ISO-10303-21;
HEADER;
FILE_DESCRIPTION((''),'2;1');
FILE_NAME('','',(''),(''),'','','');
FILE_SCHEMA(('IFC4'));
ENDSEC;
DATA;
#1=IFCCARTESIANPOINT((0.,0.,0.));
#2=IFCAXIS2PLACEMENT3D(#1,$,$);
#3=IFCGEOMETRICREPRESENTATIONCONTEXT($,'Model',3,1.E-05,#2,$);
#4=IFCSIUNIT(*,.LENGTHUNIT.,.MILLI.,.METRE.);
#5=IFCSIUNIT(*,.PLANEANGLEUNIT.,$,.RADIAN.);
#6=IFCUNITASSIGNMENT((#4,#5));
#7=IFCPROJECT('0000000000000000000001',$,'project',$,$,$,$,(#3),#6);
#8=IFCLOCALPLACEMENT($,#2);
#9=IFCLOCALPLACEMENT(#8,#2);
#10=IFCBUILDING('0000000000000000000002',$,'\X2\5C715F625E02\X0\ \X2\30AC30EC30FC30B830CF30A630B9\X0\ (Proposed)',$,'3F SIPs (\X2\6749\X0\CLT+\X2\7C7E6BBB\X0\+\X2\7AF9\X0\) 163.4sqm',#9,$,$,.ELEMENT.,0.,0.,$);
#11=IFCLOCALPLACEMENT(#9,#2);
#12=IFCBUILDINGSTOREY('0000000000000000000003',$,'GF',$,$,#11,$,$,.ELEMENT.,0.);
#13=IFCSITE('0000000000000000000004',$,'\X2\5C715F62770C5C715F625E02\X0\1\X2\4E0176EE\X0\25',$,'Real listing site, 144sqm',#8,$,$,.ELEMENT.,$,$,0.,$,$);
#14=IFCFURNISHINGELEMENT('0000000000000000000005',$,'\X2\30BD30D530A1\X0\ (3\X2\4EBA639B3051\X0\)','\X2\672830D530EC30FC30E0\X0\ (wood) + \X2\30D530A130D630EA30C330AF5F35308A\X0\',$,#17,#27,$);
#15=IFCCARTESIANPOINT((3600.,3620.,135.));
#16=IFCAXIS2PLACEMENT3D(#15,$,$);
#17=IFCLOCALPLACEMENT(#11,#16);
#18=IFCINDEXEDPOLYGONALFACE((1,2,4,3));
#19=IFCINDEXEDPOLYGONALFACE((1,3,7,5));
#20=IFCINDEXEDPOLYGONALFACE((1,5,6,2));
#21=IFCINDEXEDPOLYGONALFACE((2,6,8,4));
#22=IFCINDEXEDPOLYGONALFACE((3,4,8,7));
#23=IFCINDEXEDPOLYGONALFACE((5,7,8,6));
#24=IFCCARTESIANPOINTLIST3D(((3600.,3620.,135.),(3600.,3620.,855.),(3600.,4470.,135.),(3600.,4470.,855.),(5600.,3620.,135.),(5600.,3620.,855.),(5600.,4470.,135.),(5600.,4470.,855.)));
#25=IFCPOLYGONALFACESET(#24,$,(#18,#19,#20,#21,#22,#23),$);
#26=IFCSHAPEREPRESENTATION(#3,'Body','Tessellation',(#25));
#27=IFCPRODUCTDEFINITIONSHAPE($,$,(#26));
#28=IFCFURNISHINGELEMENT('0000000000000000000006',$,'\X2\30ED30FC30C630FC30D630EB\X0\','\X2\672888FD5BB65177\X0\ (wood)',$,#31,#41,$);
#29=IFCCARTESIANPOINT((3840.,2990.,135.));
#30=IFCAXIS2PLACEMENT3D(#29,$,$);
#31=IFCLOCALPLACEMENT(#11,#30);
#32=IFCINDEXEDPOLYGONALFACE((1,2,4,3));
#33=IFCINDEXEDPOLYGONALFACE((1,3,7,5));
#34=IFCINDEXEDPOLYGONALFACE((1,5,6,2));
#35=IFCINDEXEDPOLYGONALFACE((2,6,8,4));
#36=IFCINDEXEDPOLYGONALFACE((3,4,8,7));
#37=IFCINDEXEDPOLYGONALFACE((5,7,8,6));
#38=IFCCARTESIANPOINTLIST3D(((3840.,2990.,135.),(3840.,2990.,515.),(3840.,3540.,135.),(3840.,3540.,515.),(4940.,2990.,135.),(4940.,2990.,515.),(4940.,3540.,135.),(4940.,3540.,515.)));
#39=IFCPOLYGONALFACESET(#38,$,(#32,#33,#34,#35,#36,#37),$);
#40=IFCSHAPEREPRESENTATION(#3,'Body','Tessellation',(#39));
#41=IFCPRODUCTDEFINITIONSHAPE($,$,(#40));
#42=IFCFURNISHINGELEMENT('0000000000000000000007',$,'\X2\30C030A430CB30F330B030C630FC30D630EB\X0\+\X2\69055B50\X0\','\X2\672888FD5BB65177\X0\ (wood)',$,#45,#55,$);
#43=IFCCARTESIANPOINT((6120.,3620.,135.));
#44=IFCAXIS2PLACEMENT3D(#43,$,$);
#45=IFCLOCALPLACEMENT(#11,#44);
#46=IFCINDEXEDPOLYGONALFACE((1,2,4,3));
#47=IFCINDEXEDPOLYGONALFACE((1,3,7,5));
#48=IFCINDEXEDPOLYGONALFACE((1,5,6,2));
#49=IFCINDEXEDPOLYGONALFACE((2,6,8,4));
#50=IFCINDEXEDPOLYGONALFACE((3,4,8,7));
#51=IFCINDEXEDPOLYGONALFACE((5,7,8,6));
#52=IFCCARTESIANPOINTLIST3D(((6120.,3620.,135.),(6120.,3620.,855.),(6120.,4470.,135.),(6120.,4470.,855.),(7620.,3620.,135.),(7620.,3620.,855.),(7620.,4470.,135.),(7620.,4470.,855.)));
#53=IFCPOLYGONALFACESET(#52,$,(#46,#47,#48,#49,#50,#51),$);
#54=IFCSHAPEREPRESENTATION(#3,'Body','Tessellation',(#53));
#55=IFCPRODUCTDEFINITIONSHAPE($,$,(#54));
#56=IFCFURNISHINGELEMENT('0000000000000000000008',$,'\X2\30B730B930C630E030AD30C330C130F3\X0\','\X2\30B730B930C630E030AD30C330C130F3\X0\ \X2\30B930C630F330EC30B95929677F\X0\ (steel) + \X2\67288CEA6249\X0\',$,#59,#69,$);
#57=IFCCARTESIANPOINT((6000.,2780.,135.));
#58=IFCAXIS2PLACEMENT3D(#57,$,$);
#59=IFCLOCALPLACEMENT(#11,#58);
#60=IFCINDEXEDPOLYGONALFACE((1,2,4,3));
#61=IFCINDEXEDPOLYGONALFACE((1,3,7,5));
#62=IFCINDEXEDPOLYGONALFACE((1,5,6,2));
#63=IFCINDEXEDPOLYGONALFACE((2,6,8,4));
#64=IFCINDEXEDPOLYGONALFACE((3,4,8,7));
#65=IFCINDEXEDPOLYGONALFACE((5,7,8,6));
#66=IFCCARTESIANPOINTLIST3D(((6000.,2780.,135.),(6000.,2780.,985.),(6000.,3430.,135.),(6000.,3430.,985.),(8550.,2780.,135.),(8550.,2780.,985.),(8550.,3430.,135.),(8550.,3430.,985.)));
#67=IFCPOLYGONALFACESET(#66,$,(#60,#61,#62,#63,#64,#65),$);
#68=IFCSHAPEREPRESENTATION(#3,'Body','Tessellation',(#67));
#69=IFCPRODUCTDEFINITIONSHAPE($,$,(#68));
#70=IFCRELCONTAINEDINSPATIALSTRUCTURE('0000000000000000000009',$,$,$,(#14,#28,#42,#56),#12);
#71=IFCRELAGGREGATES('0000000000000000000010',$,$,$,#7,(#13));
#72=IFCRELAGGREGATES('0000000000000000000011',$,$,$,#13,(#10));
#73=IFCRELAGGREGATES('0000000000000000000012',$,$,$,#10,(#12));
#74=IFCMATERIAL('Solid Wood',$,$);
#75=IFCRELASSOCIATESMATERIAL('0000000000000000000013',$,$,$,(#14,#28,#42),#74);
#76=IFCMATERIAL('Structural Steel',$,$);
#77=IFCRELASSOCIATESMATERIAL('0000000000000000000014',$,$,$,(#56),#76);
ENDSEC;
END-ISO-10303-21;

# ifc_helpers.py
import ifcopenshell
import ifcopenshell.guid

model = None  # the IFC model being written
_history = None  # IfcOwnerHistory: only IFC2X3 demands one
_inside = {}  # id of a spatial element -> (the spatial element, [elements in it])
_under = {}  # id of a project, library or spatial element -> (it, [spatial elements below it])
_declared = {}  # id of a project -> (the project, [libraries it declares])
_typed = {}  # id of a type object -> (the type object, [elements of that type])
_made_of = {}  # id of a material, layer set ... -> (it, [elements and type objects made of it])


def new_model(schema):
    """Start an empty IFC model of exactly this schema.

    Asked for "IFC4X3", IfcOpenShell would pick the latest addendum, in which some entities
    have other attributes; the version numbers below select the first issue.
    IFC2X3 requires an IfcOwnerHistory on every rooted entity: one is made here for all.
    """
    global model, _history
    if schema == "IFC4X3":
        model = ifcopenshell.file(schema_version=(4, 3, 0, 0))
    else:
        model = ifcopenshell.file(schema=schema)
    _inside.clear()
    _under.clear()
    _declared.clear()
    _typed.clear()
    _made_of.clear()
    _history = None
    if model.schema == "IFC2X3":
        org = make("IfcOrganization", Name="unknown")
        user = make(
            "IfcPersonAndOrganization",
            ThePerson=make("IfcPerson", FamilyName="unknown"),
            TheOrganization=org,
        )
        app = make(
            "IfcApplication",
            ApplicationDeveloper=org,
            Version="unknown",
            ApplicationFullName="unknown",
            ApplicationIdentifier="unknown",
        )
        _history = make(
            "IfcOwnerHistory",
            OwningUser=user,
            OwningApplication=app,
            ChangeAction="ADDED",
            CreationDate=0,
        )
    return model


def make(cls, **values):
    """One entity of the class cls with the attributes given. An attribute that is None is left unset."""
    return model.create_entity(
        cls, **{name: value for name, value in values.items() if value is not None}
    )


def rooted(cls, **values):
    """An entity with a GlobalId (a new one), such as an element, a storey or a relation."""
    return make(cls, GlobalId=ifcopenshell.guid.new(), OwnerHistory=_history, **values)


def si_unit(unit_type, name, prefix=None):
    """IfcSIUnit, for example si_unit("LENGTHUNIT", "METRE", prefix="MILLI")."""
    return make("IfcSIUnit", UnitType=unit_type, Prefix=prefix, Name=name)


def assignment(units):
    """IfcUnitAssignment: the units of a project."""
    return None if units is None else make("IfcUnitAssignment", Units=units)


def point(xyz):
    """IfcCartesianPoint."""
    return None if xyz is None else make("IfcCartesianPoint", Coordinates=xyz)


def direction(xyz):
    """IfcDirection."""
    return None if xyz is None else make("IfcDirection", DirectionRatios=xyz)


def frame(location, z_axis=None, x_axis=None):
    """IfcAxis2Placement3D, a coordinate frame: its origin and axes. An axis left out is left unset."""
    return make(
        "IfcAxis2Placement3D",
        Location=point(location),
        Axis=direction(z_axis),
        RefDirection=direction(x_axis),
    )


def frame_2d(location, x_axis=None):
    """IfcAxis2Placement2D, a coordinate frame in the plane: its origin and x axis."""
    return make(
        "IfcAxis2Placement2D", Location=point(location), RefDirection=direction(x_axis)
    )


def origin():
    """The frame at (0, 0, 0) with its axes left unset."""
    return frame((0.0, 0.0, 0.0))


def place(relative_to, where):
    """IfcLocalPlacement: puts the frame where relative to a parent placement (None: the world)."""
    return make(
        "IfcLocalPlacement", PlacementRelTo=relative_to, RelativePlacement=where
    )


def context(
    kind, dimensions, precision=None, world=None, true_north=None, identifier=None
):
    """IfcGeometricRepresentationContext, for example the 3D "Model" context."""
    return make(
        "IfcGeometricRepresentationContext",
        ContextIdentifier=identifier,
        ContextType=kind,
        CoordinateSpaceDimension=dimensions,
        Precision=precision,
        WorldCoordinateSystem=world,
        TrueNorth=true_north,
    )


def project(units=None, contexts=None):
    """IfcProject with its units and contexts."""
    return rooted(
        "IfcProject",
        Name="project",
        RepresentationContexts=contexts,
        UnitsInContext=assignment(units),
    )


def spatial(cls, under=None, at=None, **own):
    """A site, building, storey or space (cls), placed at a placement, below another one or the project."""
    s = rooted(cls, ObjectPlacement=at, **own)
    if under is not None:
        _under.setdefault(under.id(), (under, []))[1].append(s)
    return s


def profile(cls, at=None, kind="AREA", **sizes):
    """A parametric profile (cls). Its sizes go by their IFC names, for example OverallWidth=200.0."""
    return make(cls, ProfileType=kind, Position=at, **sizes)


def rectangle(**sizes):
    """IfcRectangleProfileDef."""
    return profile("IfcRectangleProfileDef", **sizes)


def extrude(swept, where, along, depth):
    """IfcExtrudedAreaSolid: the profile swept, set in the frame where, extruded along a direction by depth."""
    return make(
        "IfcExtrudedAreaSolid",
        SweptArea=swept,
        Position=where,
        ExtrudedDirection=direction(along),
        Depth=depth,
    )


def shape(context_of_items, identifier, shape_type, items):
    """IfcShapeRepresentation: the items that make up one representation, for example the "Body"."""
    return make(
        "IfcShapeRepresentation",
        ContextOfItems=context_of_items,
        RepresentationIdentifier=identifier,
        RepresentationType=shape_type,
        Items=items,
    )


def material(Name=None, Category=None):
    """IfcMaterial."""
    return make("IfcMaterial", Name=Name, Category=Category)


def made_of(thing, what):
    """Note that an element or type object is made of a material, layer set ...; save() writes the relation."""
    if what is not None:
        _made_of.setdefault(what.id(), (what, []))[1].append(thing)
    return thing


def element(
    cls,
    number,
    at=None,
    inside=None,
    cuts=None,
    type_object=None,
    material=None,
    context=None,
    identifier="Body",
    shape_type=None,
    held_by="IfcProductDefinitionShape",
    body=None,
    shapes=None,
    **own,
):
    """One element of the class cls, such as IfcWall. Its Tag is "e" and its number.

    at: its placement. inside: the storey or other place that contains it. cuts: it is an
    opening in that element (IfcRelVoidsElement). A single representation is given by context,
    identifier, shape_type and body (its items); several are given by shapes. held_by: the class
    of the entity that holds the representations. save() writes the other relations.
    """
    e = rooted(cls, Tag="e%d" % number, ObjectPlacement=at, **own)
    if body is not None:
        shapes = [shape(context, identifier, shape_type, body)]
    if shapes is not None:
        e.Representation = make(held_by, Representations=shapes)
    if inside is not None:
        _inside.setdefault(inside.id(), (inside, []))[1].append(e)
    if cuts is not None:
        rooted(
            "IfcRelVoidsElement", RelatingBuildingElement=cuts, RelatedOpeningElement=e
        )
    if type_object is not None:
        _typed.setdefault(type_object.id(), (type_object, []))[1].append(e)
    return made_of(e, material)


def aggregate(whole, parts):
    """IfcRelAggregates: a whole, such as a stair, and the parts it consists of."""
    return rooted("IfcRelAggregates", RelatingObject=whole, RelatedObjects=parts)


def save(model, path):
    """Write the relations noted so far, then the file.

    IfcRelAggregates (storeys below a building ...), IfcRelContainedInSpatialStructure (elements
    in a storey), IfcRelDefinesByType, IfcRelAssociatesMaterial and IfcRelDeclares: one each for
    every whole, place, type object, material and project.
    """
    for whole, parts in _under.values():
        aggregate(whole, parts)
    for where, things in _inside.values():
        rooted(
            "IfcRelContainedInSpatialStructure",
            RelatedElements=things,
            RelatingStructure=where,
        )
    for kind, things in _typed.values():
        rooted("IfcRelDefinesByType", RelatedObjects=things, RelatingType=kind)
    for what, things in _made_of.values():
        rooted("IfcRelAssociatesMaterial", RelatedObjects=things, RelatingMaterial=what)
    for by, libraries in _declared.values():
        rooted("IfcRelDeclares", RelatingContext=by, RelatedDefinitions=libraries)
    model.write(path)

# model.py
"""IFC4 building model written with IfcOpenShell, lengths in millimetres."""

from ifc_helpers import new_model, si_unit, frame, frame_2d, origin, place, context, project, spatial, rectangle, extrude, material, element, save


model = new_model("IFC4")

# Units and contexts
model_context = context("Model", 3, precision=1e-05, world=origin())
ifc_project = project(units=[si_unit("LENGTHUNIT", "METRE", prefix="MILLI"), si_unit("PLANEANGLEUNIT", "RADIAN")], contexts=[model_context])

# Site, building, storey
site_placement = place(None, origin())
site = spatial("IfcSite", under=ifc_project, at=site_placement, Name="山形県山形市1丁目25", ObjectType="Real listing site, 144sqm", CompositionType="ELEMENT", RefElevation=0.0)
building_placement = place(site_placement, origin())
building = spatial("IfcBuilding", under=site, at=building_placement, Name="山形市 ガレージハウス (Proposed)", ObjectType="3F SIPs (杉CLT+籾殻+竹) 163.4sqm", CompositionType="ELEMENT", ElevationOfRefHeight=0.0, ElevationOfTerrain=0.0)
storey_placement = place(building_placement, origin())
storey = spatial("IfcBuildingStorey", under=building, at=storey_placement, Name="GF", CompositionType="ELEMENT", Elevation=0.0)

# Shared definitions
ifc_material_1 = material(Name="Solid Wood")

# Furnishing elements
furnishing_1_placement = place(storey_placement, frame((3600.0, 3620.0, 135.0)))
element("IfcFurnishingElement", 1, at=furnishing_1_placement, inside=storey, material=ifc_material_1, Name="ソファ (3人掛け)", Description="木フレーム (wood) + ファブリック張り", context=model_context, shape_type="SweptSolid", body=[
    extrude(rectangle(XDim=2000.0, YDim=850.0, at=frame_2d((1000.0, 425.0))), frame((3600.0, 3620.0, 135.0)), (0.0, 0.0, 1.0), 720.0),
])
furnishing_2_placement = place(storey_placement, frame((3840.0, 2990.0, 135.0)))
element("IfcFurnishingElement", 2, at=furnishing_2_placement, inside=storey, material=ifc_material_1, Name="ローテーブル", Description="木製家具 (wood)", context=model_context, shape_type="SweptSolid", body=[
    extrude(rectangle(XDim=1100.0, YDim=550.0, at=frame_2d((550.0, 275.0))), frame((3840.0, 2990.0, 135.0)), (0.0, 0.0, 1.0), 380.0),
])
furnishing_3_placement = place(storey_placement, frame((6120.0, 3620.0, 135.0)))
element("IfcFurnishingElement", 3, at=furnishing_3_placement, inside=storey, material=ifc_material_1, Name="ダイニングテーブル+椅子", Description="木製家具 (wood)", context=model_context, shape_type="SweptSolid", body=[
    extrude(rectangle(XDim=1500.0, YDim=850.0, at=frame_2d((750.0, 425.0))), frame((6120.0, 3620.0, 135.0)), (0.0, 0.0, 1.0), 720.0),
])
ifc_material_2 = material(Name="Structural Steel")
furnishing_4_placement = place(storey_placement, frame((6000.0, 2780.0, 135.0)))
element("IfcFurnishingElement", 4, at=furnishing_4_placement, inside=storey, material=ifc_material_2, Name="システムキッチン", Description="システムキッチン ステンレス天板 (steel) + 木質扉", context=model_context, shape_type="SweptSolid", body=[
    extrude(rectangle(XDim=2550.0, YDim=650.0, at=frame_2d((1275.0, 325.0))), frame((6000.0, 2780.0, 135.0)), (0.0, 0.0, 1.0), 850.0),
])

save(model, "model.ifc")
